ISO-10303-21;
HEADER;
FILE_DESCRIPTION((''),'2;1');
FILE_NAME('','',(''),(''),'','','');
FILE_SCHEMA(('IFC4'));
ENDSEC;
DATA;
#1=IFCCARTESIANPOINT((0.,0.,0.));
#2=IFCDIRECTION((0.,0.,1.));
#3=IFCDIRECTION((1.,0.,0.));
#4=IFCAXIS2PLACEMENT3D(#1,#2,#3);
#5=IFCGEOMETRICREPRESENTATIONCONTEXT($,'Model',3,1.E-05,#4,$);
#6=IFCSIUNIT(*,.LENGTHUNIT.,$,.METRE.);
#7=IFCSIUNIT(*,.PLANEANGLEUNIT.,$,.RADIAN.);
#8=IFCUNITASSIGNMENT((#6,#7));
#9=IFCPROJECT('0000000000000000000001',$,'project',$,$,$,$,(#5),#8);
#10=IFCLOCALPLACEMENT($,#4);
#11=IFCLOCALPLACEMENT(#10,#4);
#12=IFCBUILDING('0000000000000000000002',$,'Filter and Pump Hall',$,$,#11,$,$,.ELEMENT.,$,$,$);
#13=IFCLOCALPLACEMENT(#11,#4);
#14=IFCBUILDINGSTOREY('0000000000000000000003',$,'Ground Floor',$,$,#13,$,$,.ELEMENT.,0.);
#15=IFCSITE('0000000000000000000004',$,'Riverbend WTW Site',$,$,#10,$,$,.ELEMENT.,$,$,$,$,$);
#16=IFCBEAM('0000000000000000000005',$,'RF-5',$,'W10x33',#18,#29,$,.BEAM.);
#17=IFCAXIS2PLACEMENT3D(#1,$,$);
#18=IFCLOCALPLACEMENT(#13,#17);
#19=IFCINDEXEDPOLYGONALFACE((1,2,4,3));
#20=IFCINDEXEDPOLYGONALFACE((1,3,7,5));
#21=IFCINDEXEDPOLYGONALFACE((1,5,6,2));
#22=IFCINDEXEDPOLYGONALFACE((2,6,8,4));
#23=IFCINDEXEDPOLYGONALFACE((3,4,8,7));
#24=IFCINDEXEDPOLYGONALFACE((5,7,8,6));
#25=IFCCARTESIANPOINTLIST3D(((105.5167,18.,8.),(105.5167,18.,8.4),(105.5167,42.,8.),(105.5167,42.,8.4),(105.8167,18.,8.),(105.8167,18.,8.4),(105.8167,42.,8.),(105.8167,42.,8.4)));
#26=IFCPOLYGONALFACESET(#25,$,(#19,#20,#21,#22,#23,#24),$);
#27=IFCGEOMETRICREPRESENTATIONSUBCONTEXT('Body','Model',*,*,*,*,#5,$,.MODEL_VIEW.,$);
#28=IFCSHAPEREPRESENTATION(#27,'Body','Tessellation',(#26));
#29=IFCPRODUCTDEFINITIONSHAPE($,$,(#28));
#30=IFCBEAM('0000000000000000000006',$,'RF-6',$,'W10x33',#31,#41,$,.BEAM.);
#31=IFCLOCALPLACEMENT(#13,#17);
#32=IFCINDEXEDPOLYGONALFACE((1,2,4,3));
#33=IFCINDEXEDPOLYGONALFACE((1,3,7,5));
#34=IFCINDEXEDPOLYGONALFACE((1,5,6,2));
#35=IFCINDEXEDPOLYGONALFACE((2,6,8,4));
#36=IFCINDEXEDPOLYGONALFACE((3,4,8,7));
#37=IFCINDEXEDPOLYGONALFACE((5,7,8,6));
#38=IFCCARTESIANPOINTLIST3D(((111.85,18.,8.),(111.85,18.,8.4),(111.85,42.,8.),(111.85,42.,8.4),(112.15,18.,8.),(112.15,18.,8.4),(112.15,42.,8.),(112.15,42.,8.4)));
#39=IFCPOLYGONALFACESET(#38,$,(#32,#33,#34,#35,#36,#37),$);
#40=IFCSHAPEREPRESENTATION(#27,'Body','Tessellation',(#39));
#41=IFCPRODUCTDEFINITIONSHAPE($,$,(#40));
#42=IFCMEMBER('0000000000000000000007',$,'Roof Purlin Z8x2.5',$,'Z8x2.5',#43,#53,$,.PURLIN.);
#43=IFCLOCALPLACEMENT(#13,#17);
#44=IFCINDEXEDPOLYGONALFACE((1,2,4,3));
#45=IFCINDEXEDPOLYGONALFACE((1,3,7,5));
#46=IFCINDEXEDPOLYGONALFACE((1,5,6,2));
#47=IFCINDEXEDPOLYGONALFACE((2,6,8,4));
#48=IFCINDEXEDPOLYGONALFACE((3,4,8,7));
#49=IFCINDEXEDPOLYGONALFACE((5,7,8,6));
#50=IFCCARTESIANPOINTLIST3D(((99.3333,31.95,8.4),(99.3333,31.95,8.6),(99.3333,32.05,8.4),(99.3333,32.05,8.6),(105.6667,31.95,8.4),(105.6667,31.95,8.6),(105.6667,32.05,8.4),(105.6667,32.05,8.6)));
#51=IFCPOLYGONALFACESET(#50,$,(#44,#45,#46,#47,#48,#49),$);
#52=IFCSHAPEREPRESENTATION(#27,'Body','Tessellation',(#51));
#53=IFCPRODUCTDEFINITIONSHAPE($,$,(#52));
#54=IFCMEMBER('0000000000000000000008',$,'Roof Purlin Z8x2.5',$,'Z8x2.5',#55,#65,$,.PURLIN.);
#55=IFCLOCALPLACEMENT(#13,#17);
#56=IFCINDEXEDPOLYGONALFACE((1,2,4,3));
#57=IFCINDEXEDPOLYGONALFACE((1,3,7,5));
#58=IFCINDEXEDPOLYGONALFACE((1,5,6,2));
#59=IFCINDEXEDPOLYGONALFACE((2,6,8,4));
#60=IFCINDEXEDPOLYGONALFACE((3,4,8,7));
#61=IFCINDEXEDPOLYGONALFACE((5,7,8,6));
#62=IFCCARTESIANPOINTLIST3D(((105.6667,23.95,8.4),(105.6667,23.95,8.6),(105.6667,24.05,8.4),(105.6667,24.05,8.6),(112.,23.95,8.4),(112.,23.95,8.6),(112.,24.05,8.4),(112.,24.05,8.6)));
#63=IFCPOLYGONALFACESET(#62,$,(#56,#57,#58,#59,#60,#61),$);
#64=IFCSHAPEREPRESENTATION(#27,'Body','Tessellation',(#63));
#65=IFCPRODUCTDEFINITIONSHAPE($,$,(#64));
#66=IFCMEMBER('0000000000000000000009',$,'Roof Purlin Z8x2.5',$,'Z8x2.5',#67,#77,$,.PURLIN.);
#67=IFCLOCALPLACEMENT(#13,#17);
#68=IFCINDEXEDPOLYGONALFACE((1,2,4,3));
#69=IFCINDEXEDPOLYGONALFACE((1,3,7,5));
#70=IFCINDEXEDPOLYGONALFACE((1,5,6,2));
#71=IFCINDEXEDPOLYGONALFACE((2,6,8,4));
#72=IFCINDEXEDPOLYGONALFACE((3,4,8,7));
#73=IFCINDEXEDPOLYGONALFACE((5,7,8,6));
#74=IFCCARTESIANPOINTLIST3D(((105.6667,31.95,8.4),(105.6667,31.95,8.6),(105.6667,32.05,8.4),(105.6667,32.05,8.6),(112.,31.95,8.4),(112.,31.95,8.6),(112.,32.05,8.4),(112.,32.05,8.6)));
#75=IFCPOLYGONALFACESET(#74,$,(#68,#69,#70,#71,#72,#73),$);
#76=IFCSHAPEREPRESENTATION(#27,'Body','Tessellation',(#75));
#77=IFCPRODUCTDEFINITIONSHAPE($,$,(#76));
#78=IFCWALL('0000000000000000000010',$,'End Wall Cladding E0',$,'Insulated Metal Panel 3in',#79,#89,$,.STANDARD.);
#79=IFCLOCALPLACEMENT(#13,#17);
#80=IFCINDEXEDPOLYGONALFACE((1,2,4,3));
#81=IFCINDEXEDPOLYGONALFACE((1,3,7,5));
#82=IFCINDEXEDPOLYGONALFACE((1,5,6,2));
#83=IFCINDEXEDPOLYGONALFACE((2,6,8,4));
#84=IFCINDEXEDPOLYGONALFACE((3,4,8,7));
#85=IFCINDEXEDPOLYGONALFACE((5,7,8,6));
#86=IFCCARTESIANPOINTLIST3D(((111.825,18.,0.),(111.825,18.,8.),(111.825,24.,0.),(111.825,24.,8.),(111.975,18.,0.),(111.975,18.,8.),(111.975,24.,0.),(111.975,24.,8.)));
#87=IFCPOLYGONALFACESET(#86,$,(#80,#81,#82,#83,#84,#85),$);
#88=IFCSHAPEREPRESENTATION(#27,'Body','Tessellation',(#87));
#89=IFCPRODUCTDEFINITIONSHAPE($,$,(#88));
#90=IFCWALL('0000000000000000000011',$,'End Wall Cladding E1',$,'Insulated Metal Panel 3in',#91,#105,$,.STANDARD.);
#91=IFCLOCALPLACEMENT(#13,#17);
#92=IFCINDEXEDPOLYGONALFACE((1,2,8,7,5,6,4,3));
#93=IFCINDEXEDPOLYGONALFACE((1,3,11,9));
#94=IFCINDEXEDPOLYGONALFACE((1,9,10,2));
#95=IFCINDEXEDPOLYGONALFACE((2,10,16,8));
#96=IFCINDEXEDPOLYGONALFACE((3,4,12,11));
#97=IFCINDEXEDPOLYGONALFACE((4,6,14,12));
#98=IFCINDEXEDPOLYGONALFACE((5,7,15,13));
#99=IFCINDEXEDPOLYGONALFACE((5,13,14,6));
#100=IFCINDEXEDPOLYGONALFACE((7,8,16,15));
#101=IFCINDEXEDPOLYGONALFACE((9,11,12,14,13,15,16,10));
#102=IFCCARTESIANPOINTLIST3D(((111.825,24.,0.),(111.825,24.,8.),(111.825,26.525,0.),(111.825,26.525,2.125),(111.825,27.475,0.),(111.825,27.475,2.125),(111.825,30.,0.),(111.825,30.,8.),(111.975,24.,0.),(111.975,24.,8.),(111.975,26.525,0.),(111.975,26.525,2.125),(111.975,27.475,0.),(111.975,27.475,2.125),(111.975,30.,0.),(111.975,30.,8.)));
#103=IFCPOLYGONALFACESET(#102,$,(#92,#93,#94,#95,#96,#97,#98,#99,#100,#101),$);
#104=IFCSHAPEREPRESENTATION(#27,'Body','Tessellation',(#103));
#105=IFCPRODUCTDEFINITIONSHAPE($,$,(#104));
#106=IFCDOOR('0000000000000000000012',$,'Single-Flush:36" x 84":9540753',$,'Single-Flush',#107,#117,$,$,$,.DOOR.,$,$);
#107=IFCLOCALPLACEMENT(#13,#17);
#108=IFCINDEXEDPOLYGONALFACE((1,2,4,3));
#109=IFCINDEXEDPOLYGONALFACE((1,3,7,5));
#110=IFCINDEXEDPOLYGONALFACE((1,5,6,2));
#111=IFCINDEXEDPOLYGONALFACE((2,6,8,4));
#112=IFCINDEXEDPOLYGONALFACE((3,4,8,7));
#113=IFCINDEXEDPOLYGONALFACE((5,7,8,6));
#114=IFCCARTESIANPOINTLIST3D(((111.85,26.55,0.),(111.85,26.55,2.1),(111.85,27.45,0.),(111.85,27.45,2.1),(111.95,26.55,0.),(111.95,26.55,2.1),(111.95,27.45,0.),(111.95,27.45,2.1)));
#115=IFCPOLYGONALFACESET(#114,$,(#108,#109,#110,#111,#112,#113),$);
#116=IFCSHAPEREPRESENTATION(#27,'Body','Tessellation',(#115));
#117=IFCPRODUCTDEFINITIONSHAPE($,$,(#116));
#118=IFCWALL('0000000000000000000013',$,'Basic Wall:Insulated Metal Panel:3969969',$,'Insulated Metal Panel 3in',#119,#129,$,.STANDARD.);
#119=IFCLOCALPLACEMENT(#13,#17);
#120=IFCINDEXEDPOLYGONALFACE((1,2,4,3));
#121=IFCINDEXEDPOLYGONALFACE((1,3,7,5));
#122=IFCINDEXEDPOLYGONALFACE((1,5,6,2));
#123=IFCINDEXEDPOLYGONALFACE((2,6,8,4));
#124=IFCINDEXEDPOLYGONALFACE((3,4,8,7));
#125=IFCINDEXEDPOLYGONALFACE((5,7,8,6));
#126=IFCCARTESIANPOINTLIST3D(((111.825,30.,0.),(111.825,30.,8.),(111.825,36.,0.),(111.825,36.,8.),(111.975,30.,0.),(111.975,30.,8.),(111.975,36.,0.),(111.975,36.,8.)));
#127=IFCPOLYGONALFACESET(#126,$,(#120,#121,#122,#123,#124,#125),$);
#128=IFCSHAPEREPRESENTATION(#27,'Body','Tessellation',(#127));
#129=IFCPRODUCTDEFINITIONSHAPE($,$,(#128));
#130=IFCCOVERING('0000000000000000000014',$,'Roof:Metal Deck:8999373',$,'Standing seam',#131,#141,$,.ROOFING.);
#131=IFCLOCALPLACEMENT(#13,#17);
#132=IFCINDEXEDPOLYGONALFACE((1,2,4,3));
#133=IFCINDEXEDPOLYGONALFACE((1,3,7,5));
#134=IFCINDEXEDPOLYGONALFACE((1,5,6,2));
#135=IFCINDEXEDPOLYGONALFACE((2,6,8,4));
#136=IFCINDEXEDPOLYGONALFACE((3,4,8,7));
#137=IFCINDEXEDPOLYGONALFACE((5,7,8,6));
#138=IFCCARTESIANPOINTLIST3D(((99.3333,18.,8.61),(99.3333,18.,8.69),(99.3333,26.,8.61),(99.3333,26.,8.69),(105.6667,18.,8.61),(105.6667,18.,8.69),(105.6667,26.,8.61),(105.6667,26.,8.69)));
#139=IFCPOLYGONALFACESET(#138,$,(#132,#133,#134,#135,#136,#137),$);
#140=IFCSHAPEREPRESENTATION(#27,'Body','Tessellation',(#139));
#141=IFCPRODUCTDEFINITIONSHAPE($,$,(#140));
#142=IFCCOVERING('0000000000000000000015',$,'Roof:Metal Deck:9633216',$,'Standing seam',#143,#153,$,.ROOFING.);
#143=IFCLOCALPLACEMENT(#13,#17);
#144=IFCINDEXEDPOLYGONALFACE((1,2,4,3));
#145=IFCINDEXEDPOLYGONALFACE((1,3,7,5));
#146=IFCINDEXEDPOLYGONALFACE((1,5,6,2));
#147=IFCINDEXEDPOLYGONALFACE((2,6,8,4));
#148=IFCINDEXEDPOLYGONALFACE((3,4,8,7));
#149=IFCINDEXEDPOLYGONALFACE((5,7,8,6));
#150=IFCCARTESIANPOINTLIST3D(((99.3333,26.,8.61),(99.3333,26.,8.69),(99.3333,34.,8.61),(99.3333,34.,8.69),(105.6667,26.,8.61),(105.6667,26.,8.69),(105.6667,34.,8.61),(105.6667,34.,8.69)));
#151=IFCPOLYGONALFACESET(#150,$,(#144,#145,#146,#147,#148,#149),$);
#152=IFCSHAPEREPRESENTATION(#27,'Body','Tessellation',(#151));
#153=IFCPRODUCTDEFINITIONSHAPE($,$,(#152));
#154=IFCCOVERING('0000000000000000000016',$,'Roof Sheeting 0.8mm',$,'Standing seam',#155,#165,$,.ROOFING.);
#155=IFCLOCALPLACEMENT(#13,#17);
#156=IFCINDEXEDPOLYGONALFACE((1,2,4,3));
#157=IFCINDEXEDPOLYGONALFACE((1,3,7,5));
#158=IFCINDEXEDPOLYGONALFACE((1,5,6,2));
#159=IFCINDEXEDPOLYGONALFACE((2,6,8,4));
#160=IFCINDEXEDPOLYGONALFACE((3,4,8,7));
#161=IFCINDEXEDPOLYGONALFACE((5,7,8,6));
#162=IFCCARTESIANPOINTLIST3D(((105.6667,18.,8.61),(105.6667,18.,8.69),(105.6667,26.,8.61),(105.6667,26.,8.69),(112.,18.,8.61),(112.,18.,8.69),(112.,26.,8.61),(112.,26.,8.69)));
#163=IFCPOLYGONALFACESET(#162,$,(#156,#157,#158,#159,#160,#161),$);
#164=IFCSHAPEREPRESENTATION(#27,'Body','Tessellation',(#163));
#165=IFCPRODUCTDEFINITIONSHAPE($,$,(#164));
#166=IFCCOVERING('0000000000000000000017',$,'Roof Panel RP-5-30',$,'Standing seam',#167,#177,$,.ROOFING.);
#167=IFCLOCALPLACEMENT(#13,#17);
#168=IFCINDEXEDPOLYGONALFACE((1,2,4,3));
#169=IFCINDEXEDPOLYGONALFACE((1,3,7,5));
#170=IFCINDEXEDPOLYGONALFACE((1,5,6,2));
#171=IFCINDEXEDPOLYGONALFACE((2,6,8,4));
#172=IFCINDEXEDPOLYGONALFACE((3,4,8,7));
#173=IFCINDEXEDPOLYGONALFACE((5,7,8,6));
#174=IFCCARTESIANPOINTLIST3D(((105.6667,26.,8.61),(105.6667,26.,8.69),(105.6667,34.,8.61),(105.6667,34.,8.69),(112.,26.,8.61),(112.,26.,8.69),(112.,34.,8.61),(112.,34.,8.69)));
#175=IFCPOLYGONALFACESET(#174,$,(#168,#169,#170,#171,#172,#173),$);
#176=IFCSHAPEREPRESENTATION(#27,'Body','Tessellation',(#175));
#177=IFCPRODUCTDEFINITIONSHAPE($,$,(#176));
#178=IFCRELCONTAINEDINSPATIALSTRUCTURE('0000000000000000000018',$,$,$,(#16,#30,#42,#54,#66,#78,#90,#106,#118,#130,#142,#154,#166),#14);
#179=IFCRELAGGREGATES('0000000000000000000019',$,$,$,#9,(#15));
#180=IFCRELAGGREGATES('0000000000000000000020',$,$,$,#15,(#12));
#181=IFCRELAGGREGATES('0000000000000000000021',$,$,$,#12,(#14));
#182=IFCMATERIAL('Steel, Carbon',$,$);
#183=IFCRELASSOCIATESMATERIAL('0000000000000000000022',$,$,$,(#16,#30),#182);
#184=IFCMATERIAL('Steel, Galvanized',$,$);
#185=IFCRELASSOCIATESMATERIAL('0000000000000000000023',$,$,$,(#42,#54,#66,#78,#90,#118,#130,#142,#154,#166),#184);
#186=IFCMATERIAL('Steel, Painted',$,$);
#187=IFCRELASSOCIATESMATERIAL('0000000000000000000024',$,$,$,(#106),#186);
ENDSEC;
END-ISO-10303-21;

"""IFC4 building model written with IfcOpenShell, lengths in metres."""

from ifc_helpers import new_model, si_unit, frame, origin_with_axes, origin_2d, place, context, subcontext, project, spatial, rectangle, extrude, material, element, fill, save


model = new_model("IFC4")

# Units and contexts
model_context = context("Model", 3, precision=1e-05, world=origin_with_axes())
body_context = subcontext(model_context, "Body", "Model", "MODEL_VIEW")
ifc_project = project(units=[si_unit("LENGTHUNIT", "METRE"), si_unit("PLANEANGLEUNIT", "RADIAN")], contexts=[model_context])

# Site, building, storey
site_placement = place(None, origin_with_axes())
site = spatial("IfcSite", under=ifc_project, at=site_placement, Name="Riverbend WTW Site", CompositionType="ELEMENT")
building_placement = place(site_placement, origin_with_axes())
building = spatial("IfcBuilding", under=site, at=building_placement, Name="Filter and Pump Hall", CompositionType="ELEMENT")
storey_placement = place(building_placement, origin_with_axes())
storey = spatial("IfcBuildingStorey", under=building, at=storey_placement, Name="Ground Floor", CompositionType="ELEMENT", Elevation=0.0)

# Beams
ifc_material_1 = material(Name="Steel, Carbon")
for number, where, z_axis, x_axis, name in (
    (1, (105.6667, 30.0, 8.2), (0.0, 0.0, 1.0), (1.0, 0.0, 0.0), "RF-5"),
    (2, (112.0, 30.0, 8.2), (0.0, 0.0, 1.0), (1.0, 0.0, 0.0), "RF-6"),
):
    element("IfcBeam", number, at=place(None, frame(where, z_axis=z_axis, x_axis=x_axis)), inside=storey, material=ifc_material_1, Name=name, ObjectType="W10x33", PredefinedType="BEAM", context=body_context, shape_type="SweptSolid", body=[
        extrude(rectangle(XDim=0.3, YDim=24.0, at=origin_2d()), frame((0.0, 0.0, -0.2), z_axis=(0.0, 0.0, 1.0), x_axis=(1.0, 0.0, 0.0)), (0.0, 0.0, 1.0), 0.4),
    ])

# Members
ifc_material_2 = material(Name="Steel, Galvanized")
member_placement = place(None, frame((102.5, 32.0, 8.5), z_axis=(0.0, 0.0, 1.0), x_axis=(1.0, 0.0, 0.0)))
element("IfcMember", 3, at=member_placement, inside=storey, material=ifc_material_2, Name="Roof Purlin Z8x2.5", ObjectType="Z8x2.5", PredefinedType="PURLIN", context=body_context, shape_type="SweptSolid", body=[
    extrude(rectangle(XDim=6.3333, YDim=0.1, at=origin_2d()), frame((0.0, 0.0, -0.1), z_axis=(0.0, 0.0, 1.0), x_axis=(1.0, 0.0, 0.0)), (0.0, 0.0, 1.0), 0.2),
])
for number, where, z_axis, x_axis, name in (
    (4, (108.8333, 24.0, 8.5), (0.0, 0.0, 1.0), (1.0, 0.0, 0.0), "Roof Purlin Z8x2.5"),
    (5, (108.8333, 32.0, 8.5), (0.0, 0.0, 1.0), (1.0, 0.0, 0.0), "Roof Purlin Z8x2.5"),
):
    element("IfcMember", number, at=place(None, frame(where, z_axis=z_axis, x_axis=x_axis)), inside=storey, material=ifc_material_2, Name=name, ObjectType="Z8x2.5", PredefinedType="PURLIN", context=body_context, shape_type="SweptSolid", body=[
        extrude(rectangle(XDim=6.3333, YDim=0.1, at=origin_2d()), frame((0.0, 0.0, -0.1), z_axis=(0.0, 0.0, 1.0), x_axis=(1.0, 0.0, 0.0)), (0.0, 0.0, 1.0), 0.2),
    ])

# Wall
wall_1_placement = place(None, frame((111.9, 21.0, 4.0), z_axis=(0.0, 0.0, 1.0), x_axis=(1.0, 0.0, 0.0)))
element("IfcWall", 6, at=wall_1_placement, inside=storey, material=ifc_material_2, Name="End Wall Cladding E0", ObjectType="Insulated Metal Panel 3in", PredefinedType="STANDARD", context=body_context, shape_type="SweptSolid", body=[
    extrude(rectangle(XDim=0.15, YDim=6.0, at=origin_2d()), frame((0.0, 0.0, -4.0), z_axis=(0.0, 0.0, 1.0), x_axis=(1.0, 0.0, 0.0)), (0.0, 0.0, 1.0), 8.0),
])

# Wall, opening, door
wall_2_placement = place(None, frame((111.9, 27.0, 4.0), z_axis=(0.0, 0.0, 1.0), x_axis=(1.0, 0.0, 0.0)))
wall_2 = element("IfcWall", 7, at=wall_2_placement, inside=storey, material=ifc_material_2, Name="End Wall Cladding E1", ObjectType="Insulated Metal Panel 3in", PredefinedType="STANDARD", context=body_context, shape_type="SweptSolid", body=[
    extrude(rectangle(XDim=0.15, YDim=6.0, at=origin_2d()), frame((0.0, 0.0, -4.0), z_axis=(0.0, 0.0, 1.0), x_axis=(1.0, 0.0, 0.0)), (0.0, 0.0, 1.0), 8.0),
])
opening_placement = place(None, frame((111.9, 27.0, 1.05), z_axis=(0.0, 0.0, 1.0), x_axis=(1.0, 0.0, 0.0)))
opening = element("IfcOpeningElement", 8, at=opening_placement, inside=storey, cuts=wall_2, context=body_context, shape_type="SweptSolid", body=[
    extrude(rectangle(XDim=0.4, YDim=0.95, at=origin_2d()), frame((0.0, 0.0, -1.075), z_axis=(0.0, 0.0, 1.0), x_axis=(1.0, 0.0, 0.0)), (0.0, 0.0, 1.0), 2.15),
])
ifc_material_3 = material(Name="Steel, Painted")
door_placement = place(None, frame((111.9, 27.0, 1.05), z_axis=(0.0, 0.0, 1.0), x_axis=(1.0, 0.0, 0.0)))
door = element("IfcDoor", 9, at=door_placement, inside=storey, material=ifc_material_3, Name="Single-Flush:36\" x 84\":9540753", ObjectType="Single-Flush", PredefinedType="DOOR", context=body_context, shape_type="SweptSolid", body=[
    extrude(rectangle(XDim=0.1, YDim=0.9, at=origin_2d()), frame((0.0, 0.0, -1.05), z_axis=(0.0, 0.0, 1.0), x_axis=(1.0, 0.0, 0.0)), (0.0, 0.0, 1.0), 2.1),
])
fill(opening, door)

# Wall
wall_3_placement = place(None, frame((111.9, 33.0, 4.0), z_axis=(0.0, 0.0, 1.0), x_axis=(1.0, 0.0, 0.0)))
element("IfcWall", 10, at=wall_3_placement, inside=storey, material=ifc_material_2, Name="Basic Wall:Insulated Metal Panel:3969969", ObjectType="Insulated Metal Panel 3in", PredefinedType="STANDARD", context=body_context, shape_type="SweptSolid", body=[
    extrude(rectangle(XDim=0.15, YDim=6.0, at=origin_2d()), frame((0.0, 0.0, -4.0), z_axis=(0.0, 0.0, 1.0), x_axis=(1.0, 0.0, 0.0)), (0.0, 0.0, 1.0), 8.0),
])

# Coverings
for number, where, z_axis, x_axis, name in (
    (11, (102.5, 22.0, 8.65), (0.0, 0.0, 1.0), (1.0, 0.0, 0.0), "Roof:Metal Deck:8999373"),
    (12, (102.5, 30.0, 8.65), (0.0, 0.0, 1.0), (1.0, 0.0, 0.0), "Roof:Metal Deck:9633216"),
):
    element("IfcCovering", number, at=place(None, frame(where, z_axis=z_axis, x_axis=x_axis)), inside=storey, material=ifc_material_2, Name=name, ObjectType="Standing seam", PredefinedType="ROOFING", context=body_context, shape_type="SweptSolid", body=[
        extrude(rectangle(XDim=6.3333, YDim=8.0, at=origin_2d()), frame((0.0, 0.0, -0.04), z_axis=(0.0, 0.0, 1.0), x_axis=(1.0, 0.0, 0.0)), (0.0, 0.0, 1.0), 0.08),
    ])
for number, where, z_axis, x_axis, name in (
    (13, (108.8333, 22.0, 8.65), (0.0, 0.0, 1.0), (1.0, 0.0, 0.0), "Roof Sheeting 0.8mm"),
    (14, (108.8333, 30.0, 8.65), (0.0, 0.0, 1.0), (1.0, 0.0, 0.0), "Roof Panel RP-5-30"),
):
    element("IfcCovering", number, at=place(None, frame(where, z_axis=z_axis, x_axis=x_axis)), inside=storey, material=ifc_material_2, Name=name, ObjectType="Standing seam", PredefinedType="ROOFING", context=body_context, shape_type="SweptSolid", body=[
        extrude(rectangle(XDim=6.3333, YDim=8.0, at=origin_2d()), frame((0.0, 0.0, -0.04), z_axis=(0.0, 0.0, 1.0), x_axis=(1.0, 0.0, 0.0)), (0.0, 0.0, 1.0), 0.08),
    ])

save(model, "model.ifc")
